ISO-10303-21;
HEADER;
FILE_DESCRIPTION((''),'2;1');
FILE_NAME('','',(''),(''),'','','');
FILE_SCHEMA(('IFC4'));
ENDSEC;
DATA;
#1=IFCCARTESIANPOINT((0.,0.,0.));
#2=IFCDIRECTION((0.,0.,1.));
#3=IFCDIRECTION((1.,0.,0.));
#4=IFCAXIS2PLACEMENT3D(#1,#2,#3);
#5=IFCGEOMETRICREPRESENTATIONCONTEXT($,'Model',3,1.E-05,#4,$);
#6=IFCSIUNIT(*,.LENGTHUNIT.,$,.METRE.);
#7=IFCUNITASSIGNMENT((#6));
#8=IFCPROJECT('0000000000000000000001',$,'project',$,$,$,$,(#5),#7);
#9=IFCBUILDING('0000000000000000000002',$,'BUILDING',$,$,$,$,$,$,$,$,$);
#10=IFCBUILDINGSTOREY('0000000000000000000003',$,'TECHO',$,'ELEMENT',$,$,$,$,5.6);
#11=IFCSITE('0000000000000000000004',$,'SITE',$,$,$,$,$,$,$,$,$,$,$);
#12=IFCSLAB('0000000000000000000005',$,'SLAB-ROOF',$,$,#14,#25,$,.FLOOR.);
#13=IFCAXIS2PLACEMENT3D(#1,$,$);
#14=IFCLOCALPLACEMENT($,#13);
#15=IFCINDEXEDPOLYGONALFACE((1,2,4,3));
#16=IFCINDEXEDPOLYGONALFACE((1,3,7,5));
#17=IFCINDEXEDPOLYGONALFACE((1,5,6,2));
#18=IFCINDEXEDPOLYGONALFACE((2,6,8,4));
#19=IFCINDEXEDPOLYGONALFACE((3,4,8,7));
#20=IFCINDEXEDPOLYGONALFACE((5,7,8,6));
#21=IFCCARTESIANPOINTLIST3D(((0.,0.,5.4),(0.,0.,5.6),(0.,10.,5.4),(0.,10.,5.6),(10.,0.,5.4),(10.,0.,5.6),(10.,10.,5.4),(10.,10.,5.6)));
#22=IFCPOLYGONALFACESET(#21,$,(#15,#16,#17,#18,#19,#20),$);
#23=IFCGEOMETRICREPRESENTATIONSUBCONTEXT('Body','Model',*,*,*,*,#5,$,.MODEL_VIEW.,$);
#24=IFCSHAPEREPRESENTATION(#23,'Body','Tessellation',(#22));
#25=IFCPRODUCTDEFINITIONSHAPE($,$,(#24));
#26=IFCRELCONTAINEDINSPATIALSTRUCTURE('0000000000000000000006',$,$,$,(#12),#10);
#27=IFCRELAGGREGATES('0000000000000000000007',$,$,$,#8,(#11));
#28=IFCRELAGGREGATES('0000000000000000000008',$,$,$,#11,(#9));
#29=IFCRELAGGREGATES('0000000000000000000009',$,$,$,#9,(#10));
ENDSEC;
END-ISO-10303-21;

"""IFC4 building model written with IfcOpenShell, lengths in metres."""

from ifc_helpers import new_model, si_unit, frame, origin_with_axes, place, context, subcontext, project, spatial, indexed_curve, outline, extrude, element, save


model = new_model("IFC4")

# Units and contexts
model_context = context("Model", 3, precision=1e-05, world=origin_with_axes())
body_context = subcontext(model_context, "Body", "Model", "MODEL_VIEW")
ifc_project = project(units=[si_unit("LENGTHUNIT", "METRE")], contexts=[model_context])

# Site, building, storey
site = spatial("IfcSite", under=ifc_project, Name="SITE")
building = spatial("IfcBuilding", under=site, Name="BUILDING")
storey = spatial("IfcBuildingStorey", under=building, Name="TECHO", ObjectType="ELEMENT", Elevation=5.6)

# Slab
slab_placement = place(None, frame((0.0, 0.0, 5.4), z_axis=(0.0, 0.0, 1.0), x_axis=(1.0, 0.0, 0.0)))
element("IfcSlab", 1, at=slab_placement, inside=storey, Name="SLAB-ROOF", PredefinedType="FLOOR", context=body_context, shape_type="SweptSolid", body=[
    extrude(outline(indexed_curve([(0.0, 0.0), (10.0, 0.0), (10.0, 10.0), (0.0, 10.0), (0.0, 0.0)])), None, (0.0, 0.0, 1.0), 0.2),
])

save(model, "model.ifc")
